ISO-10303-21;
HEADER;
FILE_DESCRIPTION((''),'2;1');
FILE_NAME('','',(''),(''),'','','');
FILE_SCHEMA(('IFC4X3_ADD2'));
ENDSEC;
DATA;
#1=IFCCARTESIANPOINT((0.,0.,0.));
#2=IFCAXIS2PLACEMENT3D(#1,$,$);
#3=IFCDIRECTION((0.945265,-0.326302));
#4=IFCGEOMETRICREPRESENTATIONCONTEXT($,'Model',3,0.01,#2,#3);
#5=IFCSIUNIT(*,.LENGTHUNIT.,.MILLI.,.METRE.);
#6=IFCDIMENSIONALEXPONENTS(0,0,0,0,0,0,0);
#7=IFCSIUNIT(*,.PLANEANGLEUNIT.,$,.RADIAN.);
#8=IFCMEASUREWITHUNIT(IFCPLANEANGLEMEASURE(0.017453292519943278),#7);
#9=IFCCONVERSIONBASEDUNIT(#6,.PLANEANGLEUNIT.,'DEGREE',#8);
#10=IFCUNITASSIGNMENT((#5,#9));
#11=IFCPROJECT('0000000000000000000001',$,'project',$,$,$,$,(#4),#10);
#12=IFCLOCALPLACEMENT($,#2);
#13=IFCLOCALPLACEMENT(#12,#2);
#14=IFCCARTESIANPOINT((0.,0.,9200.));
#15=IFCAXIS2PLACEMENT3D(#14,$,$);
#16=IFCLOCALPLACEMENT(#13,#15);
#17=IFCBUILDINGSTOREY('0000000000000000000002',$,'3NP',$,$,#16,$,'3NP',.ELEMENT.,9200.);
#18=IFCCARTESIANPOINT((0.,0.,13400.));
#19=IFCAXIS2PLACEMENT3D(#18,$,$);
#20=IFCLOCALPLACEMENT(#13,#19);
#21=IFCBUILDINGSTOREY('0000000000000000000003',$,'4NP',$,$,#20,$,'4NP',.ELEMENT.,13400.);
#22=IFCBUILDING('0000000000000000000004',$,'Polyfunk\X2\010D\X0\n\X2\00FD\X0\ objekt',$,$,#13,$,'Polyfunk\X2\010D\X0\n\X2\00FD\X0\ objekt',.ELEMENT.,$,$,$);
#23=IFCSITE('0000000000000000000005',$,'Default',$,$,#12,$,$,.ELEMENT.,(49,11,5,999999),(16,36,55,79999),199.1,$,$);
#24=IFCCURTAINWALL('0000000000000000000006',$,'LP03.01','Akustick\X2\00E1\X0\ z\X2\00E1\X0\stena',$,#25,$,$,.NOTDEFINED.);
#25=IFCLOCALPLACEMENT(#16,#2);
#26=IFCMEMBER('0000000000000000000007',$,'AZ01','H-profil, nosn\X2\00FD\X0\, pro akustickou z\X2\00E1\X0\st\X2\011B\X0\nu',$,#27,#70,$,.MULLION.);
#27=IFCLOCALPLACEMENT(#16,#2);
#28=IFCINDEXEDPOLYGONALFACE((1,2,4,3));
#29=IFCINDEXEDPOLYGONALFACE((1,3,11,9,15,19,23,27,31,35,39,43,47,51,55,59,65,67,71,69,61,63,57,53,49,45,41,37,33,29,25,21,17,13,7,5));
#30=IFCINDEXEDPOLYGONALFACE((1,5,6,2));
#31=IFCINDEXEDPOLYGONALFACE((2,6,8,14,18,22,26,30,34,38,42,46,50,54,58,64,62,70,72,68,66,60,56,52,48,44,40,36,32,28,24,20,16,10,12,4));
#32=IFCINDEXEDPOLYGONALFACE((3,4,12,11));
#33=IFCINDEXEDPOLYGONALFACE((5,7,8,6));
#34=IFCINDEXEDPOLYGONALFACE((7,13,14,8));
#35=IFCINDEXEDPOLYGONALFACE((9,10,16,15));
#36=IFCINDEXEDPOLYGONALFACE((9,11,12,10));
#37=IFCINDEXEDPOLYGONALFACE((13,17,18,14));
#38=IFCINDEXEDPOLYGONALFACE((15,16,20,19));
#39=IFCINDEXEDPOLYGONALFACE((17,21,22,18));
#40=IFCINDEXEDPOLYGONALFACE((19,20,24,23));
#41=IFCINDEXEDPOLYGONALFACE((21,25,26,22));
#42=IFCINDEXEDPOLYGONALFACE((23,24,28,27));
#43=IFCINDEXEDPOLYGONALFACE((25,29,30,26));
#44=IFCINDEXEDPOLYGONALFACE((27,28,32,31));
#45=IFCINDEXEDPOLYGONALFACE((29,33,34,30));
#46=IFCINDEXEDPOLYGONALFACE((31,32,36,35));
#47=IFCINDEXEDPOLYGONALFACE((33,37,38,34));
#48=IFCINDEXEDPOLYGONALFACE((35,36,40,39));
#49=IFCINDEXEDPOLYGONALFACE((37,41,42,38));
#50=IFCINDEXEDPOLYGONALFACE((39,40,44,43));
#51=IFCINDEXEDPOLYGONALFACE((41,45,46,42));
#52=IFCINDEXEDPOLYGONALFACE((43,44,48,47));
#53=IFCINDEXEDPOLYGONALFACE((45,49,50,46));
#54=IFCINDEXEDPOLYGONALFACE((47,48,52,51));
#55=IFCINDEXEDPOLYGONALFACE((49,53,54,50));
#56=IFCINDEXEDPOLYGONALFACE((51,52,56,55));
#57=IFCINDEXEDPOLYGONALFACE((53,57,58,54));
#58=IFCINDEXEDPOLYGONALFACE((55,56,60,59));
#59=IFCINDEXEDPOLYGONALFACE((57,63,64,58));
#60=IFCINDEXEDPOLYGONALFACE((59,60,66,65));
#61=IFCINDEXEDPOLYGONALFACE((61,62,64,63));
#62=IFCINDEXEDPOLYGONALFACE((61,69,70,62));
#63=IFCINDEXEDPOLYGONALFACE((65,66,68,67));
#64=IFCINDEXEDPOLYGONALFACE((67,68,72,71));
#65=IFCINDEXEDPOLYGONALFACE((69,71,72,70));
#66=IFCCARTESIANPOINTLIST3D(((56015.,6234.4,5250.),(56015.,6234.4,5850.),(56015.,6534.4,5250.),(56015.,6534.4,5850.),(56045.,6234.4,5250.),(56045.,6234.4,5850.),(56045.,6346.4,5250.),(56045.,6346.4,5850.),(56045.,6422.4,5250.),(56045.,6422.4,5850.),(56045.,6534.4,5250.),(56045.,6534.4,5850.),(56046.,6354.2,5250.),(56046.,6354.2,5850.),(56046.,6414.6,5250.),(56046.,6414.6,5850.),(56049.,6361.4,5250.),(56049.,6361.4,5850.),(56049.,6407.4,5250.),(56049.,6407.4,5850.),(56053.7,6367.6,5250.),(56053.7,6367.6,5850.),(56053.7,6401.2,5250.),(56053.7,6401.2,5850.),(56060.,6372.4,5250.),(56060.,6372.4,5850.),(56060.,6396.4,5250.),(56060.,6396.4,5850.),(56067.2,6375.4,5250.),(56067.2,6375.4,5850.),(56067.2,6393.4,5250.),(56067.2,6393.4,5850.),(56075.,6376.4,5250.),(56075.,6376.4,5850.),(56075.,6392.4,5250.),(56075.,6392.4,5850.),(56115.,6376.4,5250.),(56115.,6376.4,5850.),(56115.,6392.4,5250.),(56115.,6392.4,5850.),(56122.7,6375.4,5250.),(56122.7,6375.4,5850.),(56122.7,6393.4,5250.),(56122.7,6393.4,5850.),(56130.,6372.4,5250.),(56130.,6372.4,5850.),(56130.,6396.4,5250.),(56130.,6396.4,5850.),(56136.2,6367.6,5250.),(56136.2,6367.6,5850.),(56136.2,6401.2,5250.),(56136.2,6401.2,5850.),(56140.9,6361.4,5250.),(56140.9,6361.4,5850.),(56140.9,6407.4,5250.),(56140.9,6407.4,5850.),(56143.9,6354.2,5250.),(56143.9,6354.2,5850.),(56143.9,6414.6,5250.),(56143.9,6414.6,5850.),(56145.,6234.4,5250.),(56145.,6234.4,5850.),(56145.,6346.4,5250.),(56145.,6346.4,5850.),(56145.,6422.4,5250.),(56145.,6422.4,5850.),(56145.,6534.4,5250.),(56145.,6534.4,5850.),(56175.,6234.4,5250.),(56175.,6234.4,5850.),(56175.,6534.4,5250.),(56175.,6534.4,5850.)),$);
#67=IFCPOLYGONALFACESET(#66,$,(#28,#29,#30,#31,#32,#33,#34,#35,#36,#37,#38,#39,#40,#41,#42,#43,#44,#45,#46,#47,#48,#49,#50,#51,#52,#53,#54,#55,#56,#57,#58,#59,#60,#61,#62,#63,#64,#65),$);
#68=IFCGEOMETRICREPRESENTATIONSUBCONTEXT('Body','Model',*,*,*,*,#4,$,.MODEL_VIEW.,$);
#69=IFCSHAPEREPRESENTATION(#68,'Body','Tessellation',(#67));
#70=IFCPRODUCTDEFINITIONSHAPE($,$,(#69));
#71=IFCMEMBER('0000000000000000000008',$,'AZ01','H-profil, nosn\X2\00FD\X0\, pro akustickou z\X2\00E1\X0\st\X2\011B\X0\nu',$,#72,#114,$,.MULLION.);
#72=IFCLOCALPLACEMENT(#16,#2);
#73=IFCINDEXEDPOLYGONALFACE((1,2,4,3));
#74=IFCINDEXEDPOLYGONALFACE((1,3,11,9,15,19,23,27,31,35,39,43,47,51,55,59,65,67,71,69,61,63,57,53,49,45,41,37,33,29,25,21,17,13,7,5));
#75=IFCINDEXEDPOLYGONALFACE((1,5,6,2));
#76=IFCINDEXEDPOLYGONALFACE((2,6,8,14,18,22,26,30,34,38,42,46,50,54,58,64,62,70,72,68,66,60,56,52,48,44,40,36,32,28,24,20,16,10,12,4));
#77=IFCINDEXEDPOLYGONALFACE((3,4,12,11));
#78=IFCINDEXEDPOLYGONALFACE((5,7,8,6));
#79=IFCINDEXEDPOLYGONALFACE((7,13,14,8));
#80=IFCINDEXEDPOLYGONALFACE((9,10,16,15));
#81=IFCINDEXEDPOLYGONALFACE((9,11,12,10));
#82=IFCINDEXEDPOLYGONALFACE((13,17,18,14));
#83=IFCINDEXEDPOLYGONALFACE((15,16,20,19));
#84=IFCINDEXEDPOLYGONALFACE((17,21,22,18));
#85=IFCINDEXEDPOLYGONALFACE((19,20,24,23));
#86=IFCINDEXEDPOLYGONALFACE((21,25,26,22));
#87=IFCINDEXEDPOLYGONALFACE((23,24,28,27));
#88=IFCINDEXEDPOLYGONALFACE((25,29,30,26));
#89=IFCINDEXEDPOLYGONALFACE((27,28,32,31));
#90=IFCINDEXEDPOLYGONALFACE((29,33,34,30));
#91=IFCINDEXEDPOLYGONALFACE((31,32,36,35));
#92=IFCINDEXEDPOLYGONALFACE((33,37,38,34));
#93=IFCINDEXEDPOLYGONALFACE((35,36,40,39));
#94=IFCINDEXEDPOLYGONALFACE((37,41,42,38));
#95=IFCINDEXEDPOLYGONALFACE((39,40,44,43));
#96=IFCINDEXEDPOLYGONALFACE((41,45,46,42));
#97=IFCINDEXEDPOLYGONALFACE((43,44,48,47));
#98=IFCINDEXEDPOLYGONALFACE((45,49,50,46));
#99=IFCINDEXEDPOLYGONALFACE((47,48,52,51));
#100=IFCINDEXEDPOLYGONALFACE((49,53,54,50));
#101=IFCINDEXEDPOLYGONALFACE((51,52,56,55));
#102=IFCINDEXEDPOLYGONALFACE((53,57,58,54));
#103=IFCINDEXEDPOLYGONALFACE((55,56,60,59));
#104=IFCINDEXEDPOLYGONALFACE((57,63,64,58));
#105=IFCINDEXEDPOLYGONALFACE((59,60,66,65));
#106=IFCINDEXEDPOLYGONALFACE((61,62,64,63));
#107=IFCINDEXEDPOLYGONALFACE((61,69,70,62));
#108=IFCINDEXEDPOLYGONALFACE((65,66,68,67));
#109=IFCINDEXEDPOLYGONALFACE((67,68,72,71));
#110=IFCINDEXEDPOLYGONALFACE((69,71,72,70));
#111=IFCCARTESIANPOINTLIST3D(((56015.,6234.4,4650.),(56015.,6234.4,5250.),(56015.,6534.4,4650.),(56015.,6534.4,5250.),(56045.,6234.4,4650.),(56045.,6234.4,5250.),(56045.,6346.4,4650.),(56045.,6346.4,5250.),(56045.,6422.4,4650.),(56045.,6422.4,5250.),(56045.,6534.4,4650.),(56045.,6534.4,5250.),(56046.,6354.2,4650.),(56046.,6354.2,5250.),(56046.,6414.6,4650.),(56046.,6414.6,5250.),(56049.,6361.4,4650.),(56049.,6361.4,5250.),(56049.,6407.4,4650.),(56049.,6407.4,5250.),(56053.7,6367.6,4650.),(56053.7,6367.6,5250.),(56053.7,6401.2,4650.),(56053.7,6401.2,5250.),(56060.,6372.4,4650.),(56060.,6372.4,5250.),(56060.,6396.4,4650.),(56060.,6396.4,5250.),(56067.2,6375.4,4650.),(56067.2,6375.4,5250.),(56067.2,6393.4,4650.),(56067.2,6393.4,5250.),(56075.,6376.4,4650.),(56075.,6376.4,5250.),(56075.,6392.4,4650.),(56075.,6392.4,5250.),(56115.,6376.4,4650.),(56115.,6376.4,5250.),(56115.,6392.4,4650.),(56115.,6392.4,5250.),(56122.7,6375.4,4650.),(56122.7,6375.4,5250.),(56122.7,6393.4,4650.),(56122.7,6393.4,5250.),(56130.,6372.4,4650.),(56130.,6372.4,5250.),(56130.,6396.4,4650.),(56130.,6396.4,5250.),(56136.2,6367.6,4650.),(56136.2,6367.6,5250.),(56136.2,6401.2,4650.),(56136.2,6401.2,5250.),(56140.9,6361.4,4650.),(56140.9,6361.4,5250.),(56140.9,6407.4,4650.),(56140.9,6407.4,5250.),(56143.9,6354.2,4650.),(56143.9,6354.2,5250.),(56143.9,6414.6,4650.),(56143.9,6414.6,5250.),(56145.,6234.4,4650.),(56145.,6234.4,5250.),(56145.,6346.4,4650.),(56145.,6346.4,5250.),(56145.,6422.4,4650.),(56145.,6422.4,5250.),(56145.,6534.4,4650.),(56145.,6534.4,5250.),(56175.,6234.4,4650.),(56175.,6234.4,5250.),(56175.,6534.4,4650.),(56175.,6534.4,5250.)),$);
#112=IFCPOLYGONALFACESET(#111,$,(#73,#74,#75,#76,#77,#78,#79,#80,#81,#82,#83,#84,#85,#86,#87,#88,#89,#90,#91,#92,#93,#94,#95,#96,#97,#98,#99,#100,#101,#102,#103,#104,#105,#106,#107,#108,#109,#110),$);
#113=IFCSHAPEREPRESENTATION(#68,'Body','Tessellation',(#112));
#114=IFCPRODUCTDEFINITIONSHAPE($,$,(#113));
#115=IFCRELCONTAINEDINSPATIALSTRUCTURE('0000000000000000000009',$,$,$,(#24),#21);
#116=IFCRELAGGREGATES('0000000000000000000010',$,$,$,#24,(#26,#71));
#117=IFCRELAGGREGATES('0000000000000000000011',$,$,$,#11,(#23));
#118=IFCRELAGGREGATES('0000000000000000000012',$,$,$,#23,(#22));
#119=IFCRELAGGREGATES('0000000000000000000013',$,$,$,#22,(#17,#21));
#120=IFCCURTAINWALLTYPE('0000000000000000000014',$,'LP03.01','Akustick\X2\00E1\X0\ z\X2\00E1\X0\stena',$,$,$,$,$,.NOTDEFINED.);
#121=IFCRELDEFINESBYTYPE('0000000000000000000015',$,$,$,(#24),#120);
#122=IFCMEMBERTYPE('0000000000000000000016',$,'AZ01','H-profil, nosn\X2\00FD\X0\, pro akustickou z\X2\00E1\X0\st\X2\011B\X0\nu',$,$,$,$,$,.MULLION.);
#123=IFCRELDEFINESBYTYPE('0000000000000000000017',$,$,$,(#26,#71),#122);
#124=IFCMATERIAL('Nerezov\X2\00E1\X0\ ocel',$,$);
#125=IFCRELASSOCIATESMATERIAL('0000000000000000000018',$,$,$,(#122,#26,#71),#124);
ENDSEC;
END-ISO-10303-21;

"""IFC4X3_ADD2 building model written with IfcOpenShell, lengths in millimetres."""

from ifc_helpers import new_model, entity, si_unit, converted_unit, direction, frame, frame_2d, origin, place, context, subcontext, project, spatial, polyline, circle_curve, parameter, trimmed, segment, composite_curve, outline, extrude, source, transform, mapped, material, material_profile, profile_set, profile_usage, type_object, element, aggregate, save


model = new_model("IFC4X3_ADD2")

# Units and contexts
model_context = context("Model", 3, precision=0.01, world=origin(), true_north=direction((0.945265, -0.326302)))
body_context = subcontext(model_context, "Body", "Model", "MODEL_VIEW")
ifc_project = project(units=[si_unit("LENGTHUNIT", "METRE", prefix="MILLI"), converted_unit("PLANEANGLEUNIT", "DEGREE", entity("IfcPlaneAngleMeasure", 0.017453292519943278), si_unit("PLANEANGLEUNIT", "RADIAN"), dimensions=[0, 0, 0, 0, 0, 0, 0])], contexts=[model_context])

# Site, building, storey
site_placement = place(None, origin())
site = spatial("IfcSite", under=ifc_project, at=site_placement, Name="Default", CompositionType="ELEMENT", RefLatitude=(49, 11, 5, 999999), RefLongitude=(16, 36, 55, 79999), RefElevation=199.1)
building_placement = place(site_placement, origin())
building = spatial("IfcBuilding", under=site, at=building_placement, Name="Polyfunkčný objekt", LongName="Polyfunkčný objekt", CompositionType="ELEMENT")
storey_1_placement = place(building_placement, frame((0.0, 0.0, 9200.0)))
storey_1 = spatial("IfcBuildingStorey", under=building, at=storey_1_placement, Name="3NP", LongName="3NP", CompositionType="ELEMENT", Elevation=9200.0)

# Shared definitions
storey_2_placement = place(building_placement, frame((0.0, 0.0, 13400.0)))
storey_2 = spatial("IfcBuildingStorey", under=building, at=storey_2_placement, Name="4NP", LongName="4NP", CompositionType="ELEMENT", Elevation=13400.0)

# Curtain wall, members
curtain_wall_type_1 = type_object("IfcCurtainWallType", Name="LP03.01", Description="Akustická zástena", PredefinedType="NOTDEFINED")
ifc_material_1 = material(Name="Nerezová ocel")
ifc_material_profile_1 = material_profile(ifc_material_1, outline(composite_curve([segment(polyline([(50.0, -150.0), (80.0, -150.0)]), True, "CONTINUOUS"), segment(polyline([(80.0, -150.0), (80.0, 150.0)]), True, "CONTINUOUS"), segment(polyline([(80.0, 150.0), (50.0, 150.0)]), True, "CONTINUOUS"), segment(polyline([(50.0, 150.0), (50.0, 38.0)]), True, "CONTINUOUS"), segment(trimmed(circle_curve(frame_2d((20.0, 38.0), x_axis=(0.0, 1.0)), 30.0), [parameter(180.0)], [parameter(270.0)], True, "PARAMETER"), False, "CONTINUOUS"), segment(polyline([(20.0, 8.0), (-20.0, 8.0)]), True, "CONTINUOUS"), segment(trimmed(circle_curve(frame_2d((-20.0, 38.0), x_axis=(0.0, 1.0)), 30.0), [parameter(90.0)], [parameter(180.0)], True, "PARAMETER"), False, "CONTINUOUS"), segment(polyline([(-50.0, 38.0), (-50.0, 150.0)]), True, "CONTINUOUS"), segment(polyline([(-50.0, 150.0), (-80.0, 150.0)]), True, "CONTINUOUS"), segment(polyline([(-80.0, 150.0), (-80.0, -150.0)]), True, "CONTINUOUS"), segment(polyline([(-80.0, -150.0), (-50.0, -150.0)]), True, "CONTINUOUS"), segment(polyline([(-50.0, -150.0), (-50.0, -38.0)]), True, "CONTINUOUS"), segment(trimmed(circle_curve(frame_2d((-20.0, -38.0), x_axis=(0.0, 1.0)), 30.0), [parameter(0.0)], [parameter(90.0)], True, "PARAMETER"), False, "CONTINUOUS"), segment(polyline([(-20.0, -8.0), (20.0, -8.0)]), True, "CONTINUOUS"), segment(trimmed(circle_curve(frame_2d((20.0, -38.0), x_axis=(0.0, 1.0)), 30.0), [parameter(270.0)], [parameter(0.0)], True, "PARAMETER"), False, "CONTINUOUS"), segment(polyline([(50.0, -38.0), (50.0, -150.0)]), True, "CONTINUOUS")], self_intersect=False)), Name="Profil zástena")
ifc_profile_set_1 = profile_set([ifc_material_profile_1], Name="Profil zástena")
ifc_profile_usage_1 = profile_usage(ifc_profile_set_1)
member_type_1 = type_object("IfcMemberType", Name="AZ01", Description="H-profil, nosný, pro akustickou zástěnu", PredefinedType="MULLION", material=ifc_profile_set_1)
curtain_wall_1_placement = place(storey_2_placement, frame((0.0, 0.0, -13400.0)))
curtain_wall_1 = element("IfcCurtainWall", 1, at=curtain_wall_1_placement, inside=storey_2, type_object=curtain_wall_type_1, Name="LP03.01", Description="Akustická zástena", PredefinedType="NOTDEFINED")
shared_shape_1 = source(origin(), body_context, "Body", "SweptSolid", [
    extrude(outline(composite_curve([segment(polyline([(-150.0, -50.0), (-150.0, -80.0)]), True, "CONTINUOUS"), segment(polyline([(-150.0, -80.0), (150.0, -80.0)]), True, "CONTINUOUS"), segment(polyline([(150.0, -80.0), (150.0, -50.0)]), True, "CONTINUOUS"), segment(polyline([(150.0, -50.0), (38.0, -50.0)]), True, "CONTINUOUS"), segment(trimmed(circle_curve(frame_2d((38.0, -20.0), x_axis=(1.0, 0.0)), 30.0), [parameter(180.0)], [parameter(270.0)], True, "PARAMETER"), False, "CONTINUOUS"), segment(polyline([(8.0, -20.0), (8.0, 20.0)]), True, "CONTINUOUS"), segment(trimmed(circle_curve(frame_2d((38.0, 20.0), x_axis=(1.0, 0.0)), 30.0), [parameter(90.0)], [parameter(180.0)], True, "PARAMETER"), False, "CONTINUOUS"), segment(polyline([(38.0, 50.0), (150.0, 50.0)]), True, "CONTINUOUS"), segment(polyline([(150.0, 50.0), (150.0, 80.0)]), True, "CONTINUOUS"), segment(polyline([(150.0, 80.0), (-150.0, 80.0)]), True, "CONTINUOUS"), segment(polyline([(-150.0, 80.0), (-150.0, 50.0)]), True, "CONTINUOUS"), segment(polyline([(-150.0, 50.0), (-38.0, 50.0)]), True, "CONTINUOUS"), segment(trimmed(circle_curve(frame_2d((-38.0, 20.0), x_axis=(1.0, 0.0)), 30.0), [parameter(0.0)], [parameter(90.0)], True, "PARAMETER"), False, "CONTINUOUS"), segment(polyline([(-8.0, 20.0), (-8.0, -20.0)]), True, "CONTINUOUS"), segment(trimmed(circle_curve(frame_2d((-38.0, -20.0), x_axis=(1.0, 0.0)), 30.0), [parameter(270.0)], [parameter(0.0)], True, "PARAMETER"), False, "CONTINUOUS"), segment(polyline([(-38.0, -50.0), (-150.0, -50.0)]), True, "CONTINUOUS")], self_intersect=False)), frame((-150.0, 0.0, -600.0), z_axis=(0.0, 0.0, -1.0), x_axis=(1.0, 0.0, 0.0)), (0.0, 0.0, -1.0), 600.0),
])
member_1_placement = place(curtain_wall_1_placement, frame((56095.0, 6534.4, 14450.0), z_axis=(0.0, 0.0, -1.0), x_axis=(0.0, 1.0, 0.0)))
member_1 = element("IfcMember", 2, at=member_1_placement, type_object=member_type_1, material=ifc_profile_usage_1, Name="AZ01", Description="H-profil, nosný, pro akustickou zástěnu", PredefinedType="MULLION", context=body_context, shape_type="MappedRepresentation", body=[
    mapped(shared_shape_1, transform((0.0, 0.0, 0.0), scale=1.0)),
])
member_2_placement = place(curtain_wall_1_placement, frame((56095.0, 6534.4, 13850.0), z_axis=(0.0, 0.0, -1.0), x_axis=(0.0, 1.0, 0.0)))
member_2 = element("IfcMember", 3, at=member_2_placement, type_object=member_type_1, material=ifc_profile_usage_1, Name="AZ01", Description="H-profil, nosný, pro akustickou zástěnu", PredefinedType="MULLION", context=body_context, shape_type="MappedRepresentation", body=[
    mapped(shared_shape_1, transform((0.0, 0.0, 0.0), scale=1.0)),
])

aggregate(curtain_wall_1, [member_1, member_2])

save(model, "model.ifc")
